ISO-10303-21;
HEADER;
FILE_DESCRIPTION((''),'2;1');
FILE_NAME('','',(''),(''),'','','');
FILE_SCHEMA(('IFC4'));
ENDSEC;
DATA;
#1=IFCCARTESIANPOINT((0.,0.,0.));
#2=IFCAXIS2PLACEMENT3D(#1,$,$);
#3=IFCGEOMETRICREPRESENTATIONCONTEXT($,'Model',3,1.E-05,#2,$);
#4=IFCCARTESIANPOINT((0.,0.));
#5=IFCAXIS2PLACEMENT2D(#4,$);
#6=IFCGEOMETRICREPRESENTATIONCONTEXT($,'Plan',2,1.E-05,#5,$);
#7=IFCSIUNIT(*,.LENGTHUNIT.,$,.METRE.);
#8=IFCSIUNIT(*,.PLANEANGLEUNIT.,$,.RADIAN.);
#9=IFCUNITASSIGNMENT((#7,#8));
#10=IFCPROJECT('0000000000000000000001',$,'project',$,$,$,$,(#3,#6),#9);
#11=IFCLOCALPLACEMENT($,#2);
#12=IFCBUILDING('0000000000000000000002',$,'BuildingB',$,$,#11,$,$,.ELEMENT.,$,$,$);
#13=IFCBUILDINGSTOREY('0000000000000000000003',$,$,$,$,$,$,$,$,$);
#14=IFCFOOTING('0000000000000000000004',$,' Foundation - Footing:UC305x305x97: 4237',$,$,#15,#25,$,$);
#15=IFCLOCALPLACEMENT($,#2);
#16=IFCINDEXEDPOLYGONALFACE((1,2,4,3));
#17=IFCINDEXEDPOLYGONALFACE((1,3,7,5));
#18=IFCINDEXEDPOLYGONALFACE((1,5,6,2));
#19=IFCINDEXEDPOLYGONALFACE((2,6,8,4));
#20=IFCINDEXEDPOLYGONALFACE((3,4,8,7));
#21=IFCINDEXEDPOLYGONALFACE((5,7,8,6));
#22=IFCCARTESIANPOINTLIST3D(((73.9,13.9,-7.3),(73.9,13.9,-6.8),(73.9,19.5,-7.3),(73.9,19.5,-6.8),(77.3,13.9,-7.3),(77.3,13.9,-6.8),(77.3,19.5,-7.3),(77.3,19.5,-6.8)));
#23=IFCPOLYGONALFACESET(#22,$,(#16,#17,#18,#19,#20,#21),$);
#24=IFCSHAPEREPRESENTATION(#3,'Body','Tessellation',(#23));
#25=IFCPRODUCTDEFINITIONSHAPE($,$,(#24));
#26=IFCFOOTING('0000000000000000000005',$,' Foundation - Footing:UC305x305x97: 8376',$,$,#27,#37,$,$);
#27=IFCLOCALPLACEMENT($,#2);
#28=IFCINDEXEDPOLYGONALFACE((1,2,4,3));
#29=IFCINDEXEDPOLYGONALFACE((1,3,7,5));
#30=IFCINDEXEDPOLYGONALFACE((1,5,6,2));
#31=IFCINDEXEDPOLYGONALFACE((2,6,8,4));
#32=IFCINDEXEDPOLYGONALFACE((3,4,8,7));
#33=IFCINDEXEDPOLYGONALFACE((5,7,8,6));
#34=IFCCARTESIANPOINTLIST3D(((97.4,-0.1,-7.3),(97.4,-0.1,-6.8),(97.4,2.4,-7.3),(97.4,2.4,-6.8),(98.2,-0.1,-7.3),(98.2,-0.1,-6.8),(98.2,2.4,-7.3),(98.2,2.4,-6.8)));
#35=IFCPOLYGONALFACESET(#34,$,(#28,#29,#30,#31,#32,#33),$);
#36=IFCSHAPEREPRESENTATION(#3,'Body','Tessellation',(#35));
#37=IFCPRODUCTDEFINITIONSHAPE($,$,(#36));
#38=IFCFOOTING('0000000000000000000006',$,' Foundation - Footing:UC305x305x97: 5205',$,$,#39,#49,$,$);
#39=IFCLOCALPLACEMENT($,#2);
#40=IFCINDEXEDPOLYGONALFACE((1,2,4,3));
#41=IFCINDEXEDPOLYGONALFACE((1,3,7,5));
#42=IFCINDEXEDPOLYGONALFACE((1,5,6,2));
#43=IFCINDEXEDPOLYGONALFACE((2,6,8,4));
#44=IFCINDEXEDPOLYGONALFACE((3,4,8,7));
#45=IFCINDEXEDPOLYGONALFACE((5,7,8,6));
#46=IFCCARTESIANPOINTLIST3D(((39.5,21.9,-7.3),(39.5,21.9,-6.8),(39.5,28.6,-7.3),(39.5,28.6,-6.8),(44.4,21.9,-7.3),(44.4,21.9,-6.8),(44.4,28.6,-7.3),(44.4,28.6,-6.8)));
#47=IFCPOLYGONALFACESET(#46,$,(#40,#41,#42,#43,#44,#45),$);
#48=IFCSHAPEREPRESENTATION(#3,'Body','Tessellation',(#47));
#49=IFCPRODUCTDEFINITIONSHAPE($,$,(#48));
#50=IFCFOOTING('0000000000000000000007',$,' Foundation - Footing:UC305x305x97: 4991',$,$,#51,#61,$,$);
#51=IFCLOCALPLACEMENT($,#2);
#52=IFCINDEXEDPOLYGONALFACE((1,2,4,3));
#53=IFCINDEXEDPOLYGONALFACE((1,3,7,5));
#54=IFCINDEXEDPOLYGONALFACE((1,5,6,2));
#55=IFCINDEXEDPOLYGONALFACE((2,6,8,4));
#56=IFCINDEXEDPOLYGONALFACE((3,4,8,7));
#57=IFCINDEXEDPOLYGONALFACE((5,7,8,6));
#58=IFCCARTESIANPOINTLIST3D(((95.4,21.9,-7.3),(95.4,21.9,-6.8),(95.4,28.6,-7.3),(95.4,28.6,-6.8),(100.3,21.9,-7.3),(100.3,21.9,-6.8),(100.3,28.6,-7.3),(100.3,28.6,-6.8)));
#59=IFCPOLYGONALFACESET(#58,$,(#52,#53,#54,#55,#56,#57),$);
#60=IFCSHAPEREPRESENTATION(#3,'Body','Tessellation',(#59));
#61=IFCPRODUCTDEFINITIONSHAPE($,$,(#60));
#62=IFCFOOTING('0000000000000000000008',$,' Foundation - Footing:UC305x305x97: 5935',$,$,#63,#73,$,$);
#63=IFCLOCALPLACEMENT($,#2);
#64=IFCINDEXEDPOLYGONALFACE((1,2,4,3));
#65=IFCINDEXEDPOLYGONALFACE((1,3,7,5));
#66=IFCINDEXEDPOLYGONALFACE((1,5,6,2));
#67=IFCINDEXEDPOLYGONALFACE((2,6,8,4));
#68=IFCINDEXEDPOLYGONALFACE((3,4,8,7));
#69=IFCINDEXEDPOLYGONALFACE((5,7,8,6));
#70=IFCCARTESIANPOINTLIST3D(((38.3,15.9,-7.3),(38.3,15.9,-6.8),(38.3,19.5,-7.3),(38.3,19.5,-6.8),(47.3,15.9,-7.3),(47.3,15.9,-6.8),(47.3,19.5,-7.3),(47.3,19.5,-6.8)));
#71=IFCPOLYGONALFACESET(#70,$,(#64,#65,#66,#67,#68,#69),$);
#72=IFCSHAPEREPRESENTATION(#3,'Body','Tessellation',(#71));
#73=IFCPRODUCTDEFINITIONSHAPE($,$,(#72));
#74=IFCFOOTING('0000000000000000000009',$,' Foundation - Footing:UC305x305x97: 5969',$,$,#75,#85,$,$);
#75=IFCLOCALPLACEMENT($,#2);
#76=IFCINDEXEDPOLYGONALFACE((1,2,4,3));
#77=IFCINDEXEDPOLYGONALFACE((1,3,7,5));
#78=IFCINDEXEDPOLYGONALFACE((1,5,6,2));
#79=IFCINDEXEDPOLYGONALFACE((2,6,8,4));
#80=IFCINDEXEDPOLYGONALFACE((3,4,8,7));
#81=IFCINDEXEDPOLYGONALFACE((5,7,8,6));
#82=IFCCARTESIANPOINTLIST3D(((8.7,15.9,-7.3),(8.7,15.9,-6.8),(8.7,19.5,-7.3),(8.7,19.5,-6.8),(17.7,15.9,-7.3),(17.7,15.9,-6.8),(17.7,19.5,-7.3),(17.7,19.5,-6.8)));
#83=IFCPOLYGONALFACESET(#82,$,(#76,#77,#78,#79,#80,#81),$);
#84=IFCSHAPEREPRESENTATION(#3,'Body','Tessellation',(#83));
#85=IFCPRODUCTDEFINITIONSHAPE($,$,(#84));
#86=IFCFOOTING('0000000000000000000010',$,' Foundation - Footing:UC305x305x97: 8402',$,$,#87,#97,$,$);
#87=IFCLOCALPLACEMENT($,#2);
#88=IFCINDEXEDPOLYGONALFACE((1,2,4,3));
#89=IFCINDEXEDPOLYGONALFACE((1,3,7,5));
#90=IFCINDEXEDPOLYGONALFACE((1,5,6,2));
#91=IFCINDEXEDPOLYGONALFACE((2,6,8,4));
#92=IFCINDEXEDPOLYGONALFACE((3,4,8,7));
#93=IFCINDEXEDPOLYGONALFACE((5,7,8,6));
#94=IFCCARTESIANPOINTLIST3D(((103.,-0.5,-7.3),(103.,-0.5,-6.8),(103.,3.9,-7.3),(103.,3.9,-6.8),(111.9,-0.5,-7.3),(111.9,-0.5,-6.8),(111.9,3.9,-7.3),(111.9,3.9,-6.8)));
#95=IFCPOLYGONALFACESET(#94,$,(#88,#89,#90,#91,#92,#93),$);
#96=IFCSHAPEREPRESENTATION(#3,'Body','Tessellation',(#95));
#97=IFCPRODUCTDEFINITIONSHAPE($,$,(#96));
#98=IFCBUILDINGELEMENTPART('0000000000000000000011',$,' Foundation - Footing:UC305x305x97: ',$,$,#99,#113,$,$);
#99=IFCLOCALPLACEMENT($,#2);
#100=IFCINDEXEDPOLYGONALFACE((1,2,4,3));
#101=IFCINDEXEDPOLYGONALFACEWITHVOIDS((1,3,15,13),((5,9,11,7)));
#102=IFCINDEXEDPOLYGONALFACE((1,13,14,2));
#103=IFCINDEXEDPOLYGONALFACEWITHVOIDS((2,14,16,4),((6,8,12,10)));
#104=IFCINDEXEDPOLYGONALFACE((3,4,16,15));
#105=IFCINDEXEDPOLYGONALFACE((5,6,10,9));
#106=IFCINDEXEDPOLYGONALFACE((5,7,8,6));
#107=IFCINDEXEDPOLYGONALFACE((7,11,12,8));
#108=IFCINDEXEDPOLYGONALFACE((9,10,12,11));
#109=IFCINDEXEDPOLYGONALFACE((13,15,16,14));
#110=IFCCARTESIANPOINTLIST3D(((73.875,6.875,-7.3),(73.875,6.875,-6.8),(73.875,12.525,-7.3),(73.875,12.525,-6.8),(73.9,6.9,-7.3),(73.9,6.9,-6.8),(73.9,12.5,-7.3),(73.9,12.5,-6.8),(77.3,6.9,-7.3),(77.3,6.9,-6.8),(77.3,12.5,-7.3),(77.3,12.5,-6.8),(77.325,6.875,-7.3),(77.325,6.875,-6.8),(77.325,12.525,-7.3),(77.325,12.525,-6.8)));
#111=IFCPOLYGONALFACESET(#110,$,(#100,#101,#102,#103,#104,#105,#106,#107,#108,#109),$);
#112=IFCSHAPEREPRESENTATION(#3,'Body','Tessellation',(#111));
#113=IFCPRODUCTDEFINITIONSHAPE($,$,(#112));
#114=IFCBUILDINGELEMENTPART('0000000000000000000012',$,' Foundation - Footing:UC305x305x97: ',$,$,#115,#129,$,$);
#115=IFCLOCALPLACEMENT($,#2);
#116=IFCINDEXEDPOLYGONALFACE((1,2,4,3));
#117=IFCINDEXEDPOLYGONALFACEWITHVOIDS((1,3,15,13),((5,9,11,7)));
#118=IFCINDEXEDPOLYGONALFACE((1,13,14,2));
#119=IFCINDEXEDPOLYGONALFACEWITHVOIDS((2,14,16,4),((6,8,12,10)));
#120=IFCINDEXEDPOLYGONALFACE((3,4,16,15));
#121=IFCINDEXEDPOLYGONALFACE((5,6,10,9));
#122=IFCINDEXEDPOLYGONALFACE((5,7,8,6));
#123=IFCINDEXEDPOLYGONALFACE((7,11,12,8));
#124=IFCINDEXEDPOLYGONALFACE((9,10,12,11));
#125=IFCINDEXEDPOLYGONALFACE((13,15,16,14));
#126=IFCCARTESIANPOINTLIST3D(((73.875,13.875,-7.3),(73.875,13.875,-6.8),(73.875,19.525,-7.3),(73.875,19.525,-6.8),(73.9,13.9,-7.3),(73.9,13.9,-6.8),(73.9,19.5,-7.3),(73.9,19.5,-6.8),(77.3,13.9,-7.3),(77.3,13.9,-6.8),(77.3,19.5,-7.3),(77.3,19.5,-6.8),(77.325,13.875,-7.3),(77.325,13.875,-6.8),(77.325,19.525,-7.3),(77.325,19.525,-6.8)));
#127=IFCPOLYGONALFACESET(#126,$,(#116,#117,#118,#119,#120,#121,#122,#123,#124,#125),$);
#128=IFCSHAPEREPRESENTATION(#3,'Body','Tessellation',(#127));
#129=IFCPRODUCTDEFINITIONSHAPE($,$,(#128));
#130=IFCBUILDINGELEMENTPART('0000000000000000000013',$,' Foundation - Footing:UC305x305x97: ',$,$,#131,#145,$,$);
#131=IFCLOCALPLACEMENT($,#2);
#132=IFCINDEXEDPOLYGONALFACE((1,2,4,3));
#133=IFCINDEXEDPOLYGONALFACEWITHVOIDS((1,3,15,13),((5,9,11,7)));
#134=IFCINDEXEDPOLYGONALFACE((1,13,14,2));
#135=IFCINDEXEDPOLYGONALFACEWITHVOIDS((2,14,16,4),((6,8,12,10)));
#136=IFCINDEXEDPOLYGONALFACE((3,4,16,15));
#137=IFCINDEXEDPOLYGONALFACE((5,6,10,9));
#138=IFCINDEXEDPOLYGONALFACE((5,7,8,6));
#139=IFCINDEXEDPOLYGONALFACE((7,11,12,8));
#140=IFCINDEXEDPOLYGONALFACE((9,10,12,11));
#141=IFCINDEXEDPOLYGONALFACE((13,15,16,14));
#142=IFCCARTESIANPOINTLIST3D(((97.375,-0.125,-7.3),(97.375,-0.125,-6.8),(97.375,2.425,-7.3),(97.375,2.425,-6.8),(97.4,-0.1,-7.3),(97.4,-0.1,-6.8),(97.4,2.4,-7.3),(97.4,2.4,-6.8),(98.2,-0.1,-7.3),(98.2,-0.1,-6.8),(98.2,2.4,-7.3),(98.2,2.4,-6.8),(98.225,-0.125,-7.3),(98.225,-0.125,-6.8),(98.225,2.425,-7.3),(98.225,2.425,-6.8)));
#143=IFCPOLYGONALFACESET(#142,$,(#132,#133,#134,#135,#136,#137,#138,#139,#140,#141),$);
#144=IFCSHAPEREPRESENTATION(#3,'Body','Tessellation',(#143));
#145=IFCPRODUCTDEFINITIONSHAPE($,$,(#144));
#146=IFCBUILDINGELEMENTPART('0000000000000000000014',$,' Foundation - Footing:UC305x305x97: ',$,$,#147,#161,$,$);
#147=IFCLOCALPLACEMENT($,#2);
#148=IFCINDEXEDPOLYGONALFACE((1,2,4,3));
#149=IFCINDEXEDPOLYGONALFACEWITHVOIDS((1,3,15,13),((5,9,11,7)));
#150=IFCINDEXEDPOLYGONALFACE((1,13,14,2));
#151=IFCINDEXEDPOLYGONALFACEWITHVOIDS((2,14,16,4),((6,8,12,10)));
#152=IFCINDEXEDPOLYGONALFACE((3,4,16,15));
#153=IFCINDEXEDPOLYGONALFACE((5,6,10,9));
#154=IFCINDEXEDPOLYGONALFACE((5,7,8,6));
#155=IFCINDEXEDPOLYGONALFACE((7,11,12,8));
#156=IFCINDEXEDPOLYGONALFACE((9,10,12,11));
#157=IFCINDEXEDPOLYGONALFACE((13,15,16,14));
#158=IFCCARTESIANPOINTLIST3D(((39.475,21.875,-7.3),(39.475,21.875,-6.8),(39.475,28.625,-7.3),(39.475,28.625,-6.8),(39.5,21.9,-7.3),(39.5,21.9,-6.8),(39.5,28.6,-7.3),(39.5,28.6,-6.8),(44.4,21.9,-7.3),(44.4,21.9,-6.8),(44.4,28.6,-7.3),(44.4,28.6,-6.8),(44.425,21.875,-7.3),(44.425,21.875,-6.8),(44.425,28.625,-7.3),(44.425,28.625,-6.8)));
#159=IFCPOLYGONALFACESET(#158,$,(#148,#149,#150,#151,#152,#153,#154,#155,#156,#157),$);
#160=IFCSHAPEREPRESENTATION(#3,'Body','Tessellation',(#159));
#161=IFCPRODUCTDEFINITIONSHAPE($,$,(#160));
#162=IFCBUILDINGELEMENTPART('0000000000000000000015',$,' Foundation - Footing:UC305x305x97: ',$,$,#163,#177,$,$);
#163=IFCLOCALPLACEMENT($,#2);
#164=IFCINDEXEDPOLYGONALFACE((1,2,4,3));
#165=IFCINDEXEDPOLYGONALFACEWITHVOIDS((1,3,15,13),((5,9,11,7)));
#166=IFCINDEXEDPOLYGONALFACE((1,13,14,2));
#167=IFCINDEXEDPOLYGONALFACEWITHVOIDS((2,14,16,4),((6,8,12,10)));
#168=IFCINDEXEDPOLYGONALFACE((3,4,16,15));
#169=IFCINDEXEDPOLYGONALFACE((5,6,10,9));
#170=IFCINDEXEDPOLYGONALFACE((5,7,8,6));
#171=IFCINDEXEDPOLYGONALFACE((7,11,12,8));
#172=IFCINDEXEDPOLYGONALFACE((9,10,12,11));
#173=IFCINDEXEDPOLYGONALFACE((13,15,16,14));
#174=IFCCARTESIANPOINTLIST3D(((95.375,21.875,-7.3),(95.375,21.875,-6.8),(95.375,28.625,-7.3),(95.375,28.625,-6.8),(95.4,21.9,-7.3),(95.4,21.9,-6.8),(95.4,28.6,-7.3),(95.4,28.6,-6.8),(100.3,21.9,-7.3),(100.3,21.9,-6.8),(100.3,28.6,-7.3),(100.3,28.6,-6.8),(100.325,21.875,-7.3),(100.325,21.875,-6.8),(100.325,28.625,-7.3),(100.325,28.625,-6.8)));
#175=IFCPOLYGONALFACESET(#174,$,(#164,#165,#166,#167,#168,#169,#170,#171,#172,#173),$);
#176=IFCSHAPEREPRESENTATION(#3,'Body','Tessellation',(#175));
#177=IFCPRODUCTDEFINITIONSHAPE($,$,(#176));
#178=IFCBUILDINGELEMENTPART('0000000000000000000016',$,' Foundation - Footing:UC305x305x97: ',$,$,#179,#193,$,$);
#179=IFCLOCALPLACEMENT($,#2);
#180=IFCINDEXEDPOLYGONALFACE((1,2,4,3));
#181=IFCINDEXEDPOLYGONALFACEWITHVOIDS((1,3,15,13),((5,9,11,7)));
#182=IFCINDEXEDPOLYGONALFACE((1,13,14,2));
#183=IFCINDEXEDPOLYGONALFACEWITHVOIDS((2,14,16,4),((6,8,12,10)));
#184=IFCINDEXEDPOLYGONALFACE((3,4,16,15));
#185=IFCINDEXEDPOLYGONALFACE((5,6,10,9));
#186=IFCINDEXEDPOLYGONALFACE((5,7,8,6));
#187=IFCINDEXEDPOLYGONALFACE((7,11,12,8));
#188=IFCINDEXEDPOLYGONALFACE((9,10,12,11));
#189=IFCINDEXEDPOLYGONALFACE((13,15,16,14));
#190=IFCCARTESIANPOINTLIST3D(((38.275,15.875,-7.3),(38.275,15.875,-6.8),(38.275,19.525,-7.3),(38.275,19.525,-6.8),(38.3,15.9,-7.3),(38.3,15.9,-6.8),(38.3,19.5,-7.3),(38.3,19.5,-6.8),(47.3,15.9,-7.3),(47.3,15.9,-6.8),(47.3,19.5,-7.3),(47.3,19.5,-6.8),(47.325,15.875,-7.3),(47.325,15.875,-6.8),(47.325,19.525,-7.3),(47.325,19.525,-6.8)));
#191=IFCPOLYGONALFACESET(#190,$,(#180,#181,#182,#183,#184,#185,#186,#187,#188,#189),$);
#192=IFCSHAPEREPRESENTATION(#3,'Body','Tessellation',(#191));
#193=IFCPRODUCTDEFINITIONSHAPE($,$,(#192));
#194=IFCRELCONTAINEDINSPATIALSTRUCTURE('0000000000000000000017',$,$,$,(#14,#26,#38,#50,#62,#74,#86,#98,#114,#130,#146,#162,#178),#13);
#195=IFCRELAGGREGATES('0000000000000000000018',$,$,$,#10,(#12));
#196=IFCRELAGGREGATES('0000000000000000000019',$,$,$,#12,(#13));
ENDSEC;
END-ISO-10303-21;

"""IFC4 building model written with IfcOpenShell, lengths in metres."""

from ifc_helpers import new_model, si_unit, origin, origin_2d, place, context, project, spatial, polyline, outline, extrude, element, save


model = new_model("IFC4")

# Units and contexts
model_context = context("Model", 3, precision=1e-05, world=origin())
plan_context = context("Plan", 2, precision=1e-05, world=origin_2d())
ifc_project = project(units=[si_unit("LENGTHUNIT", "METRE"), si_unit("PLANEANGLEUNIT", "RADIAN")], contexts=[model_context, plan_context])

# Building, storey
building_placement = place(None, origin())
building = spatial("IfcBuilding", under=ifc_project, at=building_placement, Name="BuildingB", CompositionType="ELEMENT")
storey = spatial("IfcBuildingStorey", under=building)

# Footings
element("IfcFooting", 1, inside=storey, Name=" Foundation - Footing:UC305x305x97: 4237", context=model_context, shape_type="SweptSolid", body=[
    extrude(outline(polyline([(73.9, 19.5, -7.3), (77.3, 19.5, -7.3), (77.3, 13.9, -7.3), (73.9, 13.9, -7.3), (73.9, 19.5, -7.3)])), None, (0.0, 0.0, 1.0), 0.5),
])
element("IfcFooting", 2, inside=storey, Name=" Foundation - Footing:UC305x305x97: 8376", context=model_context, shape_type="SweptSolid", body=[
    extrude(outline(polyline([(97.4, 2.4, -7.3), (98.2, 2.4, -7.3), (98.2, -0.1, -7.3), (97.4, -0.1, -7.3), (97.4, 2.4, -7.3)])), None, (0.0, 0.0, 1.0), 0.5),
])
element("IfcFooting", 3, inside=storey, Name=" Foundation - Footing:UC305x305x97: 5205", context=model_context, shape_type="SweptSolid", body=[
    extrude(outline(polyline([(44.4, 21.9, -7.3), (44.4, 28.6, -7.3), (39.5, 28.6, -7.3), (39.5, 21.9, -7.3), (44.4, 21.9, -7.3)])), None, (0.0, 0.0, 1.0), 0.5),
])
element("IfcFooting", 4, inside=storey, Name=" Foundation - Footing:UC305x305x97: 4991", context=model_context, shape_type="SweptSolid", body=[
    extrude(outline(polyline([(95.4, 21.9, -7.3), (95.4, 28.6, -7.3), (100.3, 28.6, -7.3), (100.3, 21.9, -7.3), (95.4, 21.9, -7.3)])), None, (0.0, 0.0, 1.0), 0.5),
])
element("IfcFooting", 5, inside=storey, Name=" Foundation - Footing:UC305x305x97: 5935", context=model_context, shape_type="SweptSolid", body=[
    extrude(outline(polyline([(47.3, 19.5, -7.3), (38.3, 19.5, -7.3), (38.3, 15.9, -7.3), (47.3, 15.9, -7.3), (47.3, 19.5, -7.3)])), None, (0.0, 0.0, 1.0), 0.5),
])
element("IfcFooting", 6, inside=storey, Name=" Foundation - Footing:UC305x305x97: 5969", context=model_context, shape_type="SweptSolid", body=[
    extrude(outline(polyline([(17.7, 19.5, -7.3), (8.7, 19.5, -7.3), (8.7, 15.9, -7.3), (17.7, 15.9, -7.3), (17.7, 19.5, -7.3)])), None, (0.0, 0.0, 1.0), 0.5),
])
element("IfcFooting", 7, inside=storey, Name=" Foundation - Footing:UC305x305x97: 8402", context=model_context, shape_type="SweptSolid", body=[
    extrude(outline(polyline([(111.9, 3.9, -7.3), (103.0, 3.9, -7.3), (103.0, -0.5, -7.3), (111.9, -0.5, -7.3), (111.9, 3.9, -7.3)])), None, (0.0, 0.0, 1.0), 0.5),
])

# Building element parts, openings
building_element_part_1 = element("IfcBuildingElementPart", 8, inside=storey, Name=" Foundation - Footing:UC305x305x97: ", context=model_context, shape_type="SweptSolid", body=[
    extrude(outline(polyline([(73.875, 12.525, -7.3), (77.325, 12.525, -7.3), (77.325, 6.875, -7.3), (73.875, 6.875, -7.3), (73.875, 12.525, -7.3)])), None, (0.0, 0.0, 1.0), 0.5),
])
element("IfcOpeningElement", 9, inside=storey, cuts=building_element_part_1, context=model_context, shape_type="SweptSolid", body=[
    extrude(outline(polyline([(73.9, 12.5, -7.3), (77.3, 12.5, -7.3), (77.3, 6.9, -7.3), (73.9, 6.9, -7.3), (73.9, 12.5, -7.3)])), None, (0.0, 0.0, 1.0), 0.5),
])
building_element_part_2 = element("IfcBuildingElementPart", 10, inside=storey, Name=" Foundation - Footing:UC305x305x97: ", context=model_context, shape_type="SweptSolid", body=[
    extrude(outline(polyline([(73.875, 19.525, -7.3), (77.325, 19.525, -7.3), (77.325, 13.875, -7.3), (73.875, 13.875, -7.3), (73.875, 19.525, -7.3)])), None, (0.0, 0.0, 1.0), 0.5),
])
element("IfcOpeningElement", 11, inside=storey, cuts=building_element_part_2, context=model_context, shape_type="SweptSolid", body=[
    extrude(outline(polyline([(73.9, 19.5, -7.3), (77.3, 19.5, -7.3), (77.3, 13.9, -7.3), (73.9, 13.9, -7.3), (73.9, 19.5, -7.3)])), None, (0.0, 0.0, 1.0), 0.5),
])
building_element_part_3 = element("IfcBuildingElementPart", 12, inside=storey, Name=" Foundation - Footing:UC305x305x97: ", context=model_context, shape_type="SweptSolid", body=[
    extrude(outline(polyline([(97.375, 2.425, -7.3), (98.225, 2.425, -7.3), (98.225, -0.125, -7.3), (97.375, -0.125, -7.3), (97.375, 2.425, -7.3)])), None, (0.0, 0.0, 1.0), 0.5),
])
element("IfcOpeningElement", 13, inside=storey, cuts=building_element_part_3, context=model_context, shape_type="SweptSolid", body=[
    extrude(outline(polyline([(97.4, 2.4, -7.3), (98.2, 2.4, -7.3), (98.2, -0.1, -7.3), (97.4, -0.1, -7.3), (97.4, 2.4, -7.3)])), None, (0.0, 0.0, 1.0), 0.5),
])
building_element_part_4 = element("IfcBuildingElementPart", 14, inside=storey, Name=" Foundation - Footing:UC305x305x97: ", context=model_context, shape_type="SweptSolid", body=[
    extrude(outline(polyline([(44.425, 21.875, -7.3), (44.425, 28.625, -7.3), (39.475, 28.625, -7.3), (39.475, 21.875, -7.3), (44.425, 21.875, -7.3)])), None, (0.0, 0.0, 1.0), 0.5),
])
element("IfcOpeningElement", 15, inside=storey, cuts=building_element_part_4, context=model_context, shape_type="SweptSolid", body=[
    extrude(outline(polyline([(44.4, 21.9, -7.3), (44.4, 28.6, -7.3), (39.5, 28.6, -7.3), (39.5, 21.9, -7.3), (44.4, 21.9, -7.3)])), None, (0.0, 0.0, 1.0), 0.5),
])
building_element_part_5 = element("IfcBuildingElementPart", 16, inside=storey, Name=" Foundation - Footing:UC305x305x97: ", context=model_context, shape_type="SweptSolid", body=[
    extrude(outline(polyline([(95.375, 21.875, -7.3), (95.375, 28.625, -7.3), (100.325, 28.625, -7.3), (100.325, 21.875, -7.3), (95.375, 21.875, -7.3)])), None, (0.0, 0.0, 1.0), 0.5),
])
element("IfcOpeningElement", 17, inside=storey, cuts=building_element_part_5, context=model_context, shape_type="SweptSolid", body=[
    extrude(outline(polyline([(95.4, 21.9, -7.3), (95.4, 28.6, -7.3), (100.3, 28.6, -7.3), (100.3, 21.9, -7.3), (95.4, 21.9, -7.3)])), None, (0.0, 0.0, 1.0), 0.5),
])
building_element_part_6 = element("IfcBuildingElementPart", 18, inside=storey, Name=" Foundation - Footing:UC305x305x97: ", context=model_context, shape_type="SweptSolid", body=[
    extrude(outline(polyline([(47.325, 19.525, -7.3), (38.275, 19.525, -7.3), (38.275, 15.875, -7.3), (47.325, 15.875, -7.3), (47.325, 19.525, -7.3)])), None, (0.0, 0.0, 1.0), 0.5),
])
element("IfcOpeningElement", 19, inside=storey, cuts=building_element_part_6, context=model_context, shape_type="SweptSolid", body=[
    extrude(outline(polyline([(47.3, 19.5, -7.3), (38.3, 19.5, -7.3), (38.3, 15.9, -7.3), (47.3, 15.9, -7.3), (47.3, 19.5, -7.3)])), None, (0.0, 0.0, 1.0), 0.5),
])

save(model, "model.ifc")
